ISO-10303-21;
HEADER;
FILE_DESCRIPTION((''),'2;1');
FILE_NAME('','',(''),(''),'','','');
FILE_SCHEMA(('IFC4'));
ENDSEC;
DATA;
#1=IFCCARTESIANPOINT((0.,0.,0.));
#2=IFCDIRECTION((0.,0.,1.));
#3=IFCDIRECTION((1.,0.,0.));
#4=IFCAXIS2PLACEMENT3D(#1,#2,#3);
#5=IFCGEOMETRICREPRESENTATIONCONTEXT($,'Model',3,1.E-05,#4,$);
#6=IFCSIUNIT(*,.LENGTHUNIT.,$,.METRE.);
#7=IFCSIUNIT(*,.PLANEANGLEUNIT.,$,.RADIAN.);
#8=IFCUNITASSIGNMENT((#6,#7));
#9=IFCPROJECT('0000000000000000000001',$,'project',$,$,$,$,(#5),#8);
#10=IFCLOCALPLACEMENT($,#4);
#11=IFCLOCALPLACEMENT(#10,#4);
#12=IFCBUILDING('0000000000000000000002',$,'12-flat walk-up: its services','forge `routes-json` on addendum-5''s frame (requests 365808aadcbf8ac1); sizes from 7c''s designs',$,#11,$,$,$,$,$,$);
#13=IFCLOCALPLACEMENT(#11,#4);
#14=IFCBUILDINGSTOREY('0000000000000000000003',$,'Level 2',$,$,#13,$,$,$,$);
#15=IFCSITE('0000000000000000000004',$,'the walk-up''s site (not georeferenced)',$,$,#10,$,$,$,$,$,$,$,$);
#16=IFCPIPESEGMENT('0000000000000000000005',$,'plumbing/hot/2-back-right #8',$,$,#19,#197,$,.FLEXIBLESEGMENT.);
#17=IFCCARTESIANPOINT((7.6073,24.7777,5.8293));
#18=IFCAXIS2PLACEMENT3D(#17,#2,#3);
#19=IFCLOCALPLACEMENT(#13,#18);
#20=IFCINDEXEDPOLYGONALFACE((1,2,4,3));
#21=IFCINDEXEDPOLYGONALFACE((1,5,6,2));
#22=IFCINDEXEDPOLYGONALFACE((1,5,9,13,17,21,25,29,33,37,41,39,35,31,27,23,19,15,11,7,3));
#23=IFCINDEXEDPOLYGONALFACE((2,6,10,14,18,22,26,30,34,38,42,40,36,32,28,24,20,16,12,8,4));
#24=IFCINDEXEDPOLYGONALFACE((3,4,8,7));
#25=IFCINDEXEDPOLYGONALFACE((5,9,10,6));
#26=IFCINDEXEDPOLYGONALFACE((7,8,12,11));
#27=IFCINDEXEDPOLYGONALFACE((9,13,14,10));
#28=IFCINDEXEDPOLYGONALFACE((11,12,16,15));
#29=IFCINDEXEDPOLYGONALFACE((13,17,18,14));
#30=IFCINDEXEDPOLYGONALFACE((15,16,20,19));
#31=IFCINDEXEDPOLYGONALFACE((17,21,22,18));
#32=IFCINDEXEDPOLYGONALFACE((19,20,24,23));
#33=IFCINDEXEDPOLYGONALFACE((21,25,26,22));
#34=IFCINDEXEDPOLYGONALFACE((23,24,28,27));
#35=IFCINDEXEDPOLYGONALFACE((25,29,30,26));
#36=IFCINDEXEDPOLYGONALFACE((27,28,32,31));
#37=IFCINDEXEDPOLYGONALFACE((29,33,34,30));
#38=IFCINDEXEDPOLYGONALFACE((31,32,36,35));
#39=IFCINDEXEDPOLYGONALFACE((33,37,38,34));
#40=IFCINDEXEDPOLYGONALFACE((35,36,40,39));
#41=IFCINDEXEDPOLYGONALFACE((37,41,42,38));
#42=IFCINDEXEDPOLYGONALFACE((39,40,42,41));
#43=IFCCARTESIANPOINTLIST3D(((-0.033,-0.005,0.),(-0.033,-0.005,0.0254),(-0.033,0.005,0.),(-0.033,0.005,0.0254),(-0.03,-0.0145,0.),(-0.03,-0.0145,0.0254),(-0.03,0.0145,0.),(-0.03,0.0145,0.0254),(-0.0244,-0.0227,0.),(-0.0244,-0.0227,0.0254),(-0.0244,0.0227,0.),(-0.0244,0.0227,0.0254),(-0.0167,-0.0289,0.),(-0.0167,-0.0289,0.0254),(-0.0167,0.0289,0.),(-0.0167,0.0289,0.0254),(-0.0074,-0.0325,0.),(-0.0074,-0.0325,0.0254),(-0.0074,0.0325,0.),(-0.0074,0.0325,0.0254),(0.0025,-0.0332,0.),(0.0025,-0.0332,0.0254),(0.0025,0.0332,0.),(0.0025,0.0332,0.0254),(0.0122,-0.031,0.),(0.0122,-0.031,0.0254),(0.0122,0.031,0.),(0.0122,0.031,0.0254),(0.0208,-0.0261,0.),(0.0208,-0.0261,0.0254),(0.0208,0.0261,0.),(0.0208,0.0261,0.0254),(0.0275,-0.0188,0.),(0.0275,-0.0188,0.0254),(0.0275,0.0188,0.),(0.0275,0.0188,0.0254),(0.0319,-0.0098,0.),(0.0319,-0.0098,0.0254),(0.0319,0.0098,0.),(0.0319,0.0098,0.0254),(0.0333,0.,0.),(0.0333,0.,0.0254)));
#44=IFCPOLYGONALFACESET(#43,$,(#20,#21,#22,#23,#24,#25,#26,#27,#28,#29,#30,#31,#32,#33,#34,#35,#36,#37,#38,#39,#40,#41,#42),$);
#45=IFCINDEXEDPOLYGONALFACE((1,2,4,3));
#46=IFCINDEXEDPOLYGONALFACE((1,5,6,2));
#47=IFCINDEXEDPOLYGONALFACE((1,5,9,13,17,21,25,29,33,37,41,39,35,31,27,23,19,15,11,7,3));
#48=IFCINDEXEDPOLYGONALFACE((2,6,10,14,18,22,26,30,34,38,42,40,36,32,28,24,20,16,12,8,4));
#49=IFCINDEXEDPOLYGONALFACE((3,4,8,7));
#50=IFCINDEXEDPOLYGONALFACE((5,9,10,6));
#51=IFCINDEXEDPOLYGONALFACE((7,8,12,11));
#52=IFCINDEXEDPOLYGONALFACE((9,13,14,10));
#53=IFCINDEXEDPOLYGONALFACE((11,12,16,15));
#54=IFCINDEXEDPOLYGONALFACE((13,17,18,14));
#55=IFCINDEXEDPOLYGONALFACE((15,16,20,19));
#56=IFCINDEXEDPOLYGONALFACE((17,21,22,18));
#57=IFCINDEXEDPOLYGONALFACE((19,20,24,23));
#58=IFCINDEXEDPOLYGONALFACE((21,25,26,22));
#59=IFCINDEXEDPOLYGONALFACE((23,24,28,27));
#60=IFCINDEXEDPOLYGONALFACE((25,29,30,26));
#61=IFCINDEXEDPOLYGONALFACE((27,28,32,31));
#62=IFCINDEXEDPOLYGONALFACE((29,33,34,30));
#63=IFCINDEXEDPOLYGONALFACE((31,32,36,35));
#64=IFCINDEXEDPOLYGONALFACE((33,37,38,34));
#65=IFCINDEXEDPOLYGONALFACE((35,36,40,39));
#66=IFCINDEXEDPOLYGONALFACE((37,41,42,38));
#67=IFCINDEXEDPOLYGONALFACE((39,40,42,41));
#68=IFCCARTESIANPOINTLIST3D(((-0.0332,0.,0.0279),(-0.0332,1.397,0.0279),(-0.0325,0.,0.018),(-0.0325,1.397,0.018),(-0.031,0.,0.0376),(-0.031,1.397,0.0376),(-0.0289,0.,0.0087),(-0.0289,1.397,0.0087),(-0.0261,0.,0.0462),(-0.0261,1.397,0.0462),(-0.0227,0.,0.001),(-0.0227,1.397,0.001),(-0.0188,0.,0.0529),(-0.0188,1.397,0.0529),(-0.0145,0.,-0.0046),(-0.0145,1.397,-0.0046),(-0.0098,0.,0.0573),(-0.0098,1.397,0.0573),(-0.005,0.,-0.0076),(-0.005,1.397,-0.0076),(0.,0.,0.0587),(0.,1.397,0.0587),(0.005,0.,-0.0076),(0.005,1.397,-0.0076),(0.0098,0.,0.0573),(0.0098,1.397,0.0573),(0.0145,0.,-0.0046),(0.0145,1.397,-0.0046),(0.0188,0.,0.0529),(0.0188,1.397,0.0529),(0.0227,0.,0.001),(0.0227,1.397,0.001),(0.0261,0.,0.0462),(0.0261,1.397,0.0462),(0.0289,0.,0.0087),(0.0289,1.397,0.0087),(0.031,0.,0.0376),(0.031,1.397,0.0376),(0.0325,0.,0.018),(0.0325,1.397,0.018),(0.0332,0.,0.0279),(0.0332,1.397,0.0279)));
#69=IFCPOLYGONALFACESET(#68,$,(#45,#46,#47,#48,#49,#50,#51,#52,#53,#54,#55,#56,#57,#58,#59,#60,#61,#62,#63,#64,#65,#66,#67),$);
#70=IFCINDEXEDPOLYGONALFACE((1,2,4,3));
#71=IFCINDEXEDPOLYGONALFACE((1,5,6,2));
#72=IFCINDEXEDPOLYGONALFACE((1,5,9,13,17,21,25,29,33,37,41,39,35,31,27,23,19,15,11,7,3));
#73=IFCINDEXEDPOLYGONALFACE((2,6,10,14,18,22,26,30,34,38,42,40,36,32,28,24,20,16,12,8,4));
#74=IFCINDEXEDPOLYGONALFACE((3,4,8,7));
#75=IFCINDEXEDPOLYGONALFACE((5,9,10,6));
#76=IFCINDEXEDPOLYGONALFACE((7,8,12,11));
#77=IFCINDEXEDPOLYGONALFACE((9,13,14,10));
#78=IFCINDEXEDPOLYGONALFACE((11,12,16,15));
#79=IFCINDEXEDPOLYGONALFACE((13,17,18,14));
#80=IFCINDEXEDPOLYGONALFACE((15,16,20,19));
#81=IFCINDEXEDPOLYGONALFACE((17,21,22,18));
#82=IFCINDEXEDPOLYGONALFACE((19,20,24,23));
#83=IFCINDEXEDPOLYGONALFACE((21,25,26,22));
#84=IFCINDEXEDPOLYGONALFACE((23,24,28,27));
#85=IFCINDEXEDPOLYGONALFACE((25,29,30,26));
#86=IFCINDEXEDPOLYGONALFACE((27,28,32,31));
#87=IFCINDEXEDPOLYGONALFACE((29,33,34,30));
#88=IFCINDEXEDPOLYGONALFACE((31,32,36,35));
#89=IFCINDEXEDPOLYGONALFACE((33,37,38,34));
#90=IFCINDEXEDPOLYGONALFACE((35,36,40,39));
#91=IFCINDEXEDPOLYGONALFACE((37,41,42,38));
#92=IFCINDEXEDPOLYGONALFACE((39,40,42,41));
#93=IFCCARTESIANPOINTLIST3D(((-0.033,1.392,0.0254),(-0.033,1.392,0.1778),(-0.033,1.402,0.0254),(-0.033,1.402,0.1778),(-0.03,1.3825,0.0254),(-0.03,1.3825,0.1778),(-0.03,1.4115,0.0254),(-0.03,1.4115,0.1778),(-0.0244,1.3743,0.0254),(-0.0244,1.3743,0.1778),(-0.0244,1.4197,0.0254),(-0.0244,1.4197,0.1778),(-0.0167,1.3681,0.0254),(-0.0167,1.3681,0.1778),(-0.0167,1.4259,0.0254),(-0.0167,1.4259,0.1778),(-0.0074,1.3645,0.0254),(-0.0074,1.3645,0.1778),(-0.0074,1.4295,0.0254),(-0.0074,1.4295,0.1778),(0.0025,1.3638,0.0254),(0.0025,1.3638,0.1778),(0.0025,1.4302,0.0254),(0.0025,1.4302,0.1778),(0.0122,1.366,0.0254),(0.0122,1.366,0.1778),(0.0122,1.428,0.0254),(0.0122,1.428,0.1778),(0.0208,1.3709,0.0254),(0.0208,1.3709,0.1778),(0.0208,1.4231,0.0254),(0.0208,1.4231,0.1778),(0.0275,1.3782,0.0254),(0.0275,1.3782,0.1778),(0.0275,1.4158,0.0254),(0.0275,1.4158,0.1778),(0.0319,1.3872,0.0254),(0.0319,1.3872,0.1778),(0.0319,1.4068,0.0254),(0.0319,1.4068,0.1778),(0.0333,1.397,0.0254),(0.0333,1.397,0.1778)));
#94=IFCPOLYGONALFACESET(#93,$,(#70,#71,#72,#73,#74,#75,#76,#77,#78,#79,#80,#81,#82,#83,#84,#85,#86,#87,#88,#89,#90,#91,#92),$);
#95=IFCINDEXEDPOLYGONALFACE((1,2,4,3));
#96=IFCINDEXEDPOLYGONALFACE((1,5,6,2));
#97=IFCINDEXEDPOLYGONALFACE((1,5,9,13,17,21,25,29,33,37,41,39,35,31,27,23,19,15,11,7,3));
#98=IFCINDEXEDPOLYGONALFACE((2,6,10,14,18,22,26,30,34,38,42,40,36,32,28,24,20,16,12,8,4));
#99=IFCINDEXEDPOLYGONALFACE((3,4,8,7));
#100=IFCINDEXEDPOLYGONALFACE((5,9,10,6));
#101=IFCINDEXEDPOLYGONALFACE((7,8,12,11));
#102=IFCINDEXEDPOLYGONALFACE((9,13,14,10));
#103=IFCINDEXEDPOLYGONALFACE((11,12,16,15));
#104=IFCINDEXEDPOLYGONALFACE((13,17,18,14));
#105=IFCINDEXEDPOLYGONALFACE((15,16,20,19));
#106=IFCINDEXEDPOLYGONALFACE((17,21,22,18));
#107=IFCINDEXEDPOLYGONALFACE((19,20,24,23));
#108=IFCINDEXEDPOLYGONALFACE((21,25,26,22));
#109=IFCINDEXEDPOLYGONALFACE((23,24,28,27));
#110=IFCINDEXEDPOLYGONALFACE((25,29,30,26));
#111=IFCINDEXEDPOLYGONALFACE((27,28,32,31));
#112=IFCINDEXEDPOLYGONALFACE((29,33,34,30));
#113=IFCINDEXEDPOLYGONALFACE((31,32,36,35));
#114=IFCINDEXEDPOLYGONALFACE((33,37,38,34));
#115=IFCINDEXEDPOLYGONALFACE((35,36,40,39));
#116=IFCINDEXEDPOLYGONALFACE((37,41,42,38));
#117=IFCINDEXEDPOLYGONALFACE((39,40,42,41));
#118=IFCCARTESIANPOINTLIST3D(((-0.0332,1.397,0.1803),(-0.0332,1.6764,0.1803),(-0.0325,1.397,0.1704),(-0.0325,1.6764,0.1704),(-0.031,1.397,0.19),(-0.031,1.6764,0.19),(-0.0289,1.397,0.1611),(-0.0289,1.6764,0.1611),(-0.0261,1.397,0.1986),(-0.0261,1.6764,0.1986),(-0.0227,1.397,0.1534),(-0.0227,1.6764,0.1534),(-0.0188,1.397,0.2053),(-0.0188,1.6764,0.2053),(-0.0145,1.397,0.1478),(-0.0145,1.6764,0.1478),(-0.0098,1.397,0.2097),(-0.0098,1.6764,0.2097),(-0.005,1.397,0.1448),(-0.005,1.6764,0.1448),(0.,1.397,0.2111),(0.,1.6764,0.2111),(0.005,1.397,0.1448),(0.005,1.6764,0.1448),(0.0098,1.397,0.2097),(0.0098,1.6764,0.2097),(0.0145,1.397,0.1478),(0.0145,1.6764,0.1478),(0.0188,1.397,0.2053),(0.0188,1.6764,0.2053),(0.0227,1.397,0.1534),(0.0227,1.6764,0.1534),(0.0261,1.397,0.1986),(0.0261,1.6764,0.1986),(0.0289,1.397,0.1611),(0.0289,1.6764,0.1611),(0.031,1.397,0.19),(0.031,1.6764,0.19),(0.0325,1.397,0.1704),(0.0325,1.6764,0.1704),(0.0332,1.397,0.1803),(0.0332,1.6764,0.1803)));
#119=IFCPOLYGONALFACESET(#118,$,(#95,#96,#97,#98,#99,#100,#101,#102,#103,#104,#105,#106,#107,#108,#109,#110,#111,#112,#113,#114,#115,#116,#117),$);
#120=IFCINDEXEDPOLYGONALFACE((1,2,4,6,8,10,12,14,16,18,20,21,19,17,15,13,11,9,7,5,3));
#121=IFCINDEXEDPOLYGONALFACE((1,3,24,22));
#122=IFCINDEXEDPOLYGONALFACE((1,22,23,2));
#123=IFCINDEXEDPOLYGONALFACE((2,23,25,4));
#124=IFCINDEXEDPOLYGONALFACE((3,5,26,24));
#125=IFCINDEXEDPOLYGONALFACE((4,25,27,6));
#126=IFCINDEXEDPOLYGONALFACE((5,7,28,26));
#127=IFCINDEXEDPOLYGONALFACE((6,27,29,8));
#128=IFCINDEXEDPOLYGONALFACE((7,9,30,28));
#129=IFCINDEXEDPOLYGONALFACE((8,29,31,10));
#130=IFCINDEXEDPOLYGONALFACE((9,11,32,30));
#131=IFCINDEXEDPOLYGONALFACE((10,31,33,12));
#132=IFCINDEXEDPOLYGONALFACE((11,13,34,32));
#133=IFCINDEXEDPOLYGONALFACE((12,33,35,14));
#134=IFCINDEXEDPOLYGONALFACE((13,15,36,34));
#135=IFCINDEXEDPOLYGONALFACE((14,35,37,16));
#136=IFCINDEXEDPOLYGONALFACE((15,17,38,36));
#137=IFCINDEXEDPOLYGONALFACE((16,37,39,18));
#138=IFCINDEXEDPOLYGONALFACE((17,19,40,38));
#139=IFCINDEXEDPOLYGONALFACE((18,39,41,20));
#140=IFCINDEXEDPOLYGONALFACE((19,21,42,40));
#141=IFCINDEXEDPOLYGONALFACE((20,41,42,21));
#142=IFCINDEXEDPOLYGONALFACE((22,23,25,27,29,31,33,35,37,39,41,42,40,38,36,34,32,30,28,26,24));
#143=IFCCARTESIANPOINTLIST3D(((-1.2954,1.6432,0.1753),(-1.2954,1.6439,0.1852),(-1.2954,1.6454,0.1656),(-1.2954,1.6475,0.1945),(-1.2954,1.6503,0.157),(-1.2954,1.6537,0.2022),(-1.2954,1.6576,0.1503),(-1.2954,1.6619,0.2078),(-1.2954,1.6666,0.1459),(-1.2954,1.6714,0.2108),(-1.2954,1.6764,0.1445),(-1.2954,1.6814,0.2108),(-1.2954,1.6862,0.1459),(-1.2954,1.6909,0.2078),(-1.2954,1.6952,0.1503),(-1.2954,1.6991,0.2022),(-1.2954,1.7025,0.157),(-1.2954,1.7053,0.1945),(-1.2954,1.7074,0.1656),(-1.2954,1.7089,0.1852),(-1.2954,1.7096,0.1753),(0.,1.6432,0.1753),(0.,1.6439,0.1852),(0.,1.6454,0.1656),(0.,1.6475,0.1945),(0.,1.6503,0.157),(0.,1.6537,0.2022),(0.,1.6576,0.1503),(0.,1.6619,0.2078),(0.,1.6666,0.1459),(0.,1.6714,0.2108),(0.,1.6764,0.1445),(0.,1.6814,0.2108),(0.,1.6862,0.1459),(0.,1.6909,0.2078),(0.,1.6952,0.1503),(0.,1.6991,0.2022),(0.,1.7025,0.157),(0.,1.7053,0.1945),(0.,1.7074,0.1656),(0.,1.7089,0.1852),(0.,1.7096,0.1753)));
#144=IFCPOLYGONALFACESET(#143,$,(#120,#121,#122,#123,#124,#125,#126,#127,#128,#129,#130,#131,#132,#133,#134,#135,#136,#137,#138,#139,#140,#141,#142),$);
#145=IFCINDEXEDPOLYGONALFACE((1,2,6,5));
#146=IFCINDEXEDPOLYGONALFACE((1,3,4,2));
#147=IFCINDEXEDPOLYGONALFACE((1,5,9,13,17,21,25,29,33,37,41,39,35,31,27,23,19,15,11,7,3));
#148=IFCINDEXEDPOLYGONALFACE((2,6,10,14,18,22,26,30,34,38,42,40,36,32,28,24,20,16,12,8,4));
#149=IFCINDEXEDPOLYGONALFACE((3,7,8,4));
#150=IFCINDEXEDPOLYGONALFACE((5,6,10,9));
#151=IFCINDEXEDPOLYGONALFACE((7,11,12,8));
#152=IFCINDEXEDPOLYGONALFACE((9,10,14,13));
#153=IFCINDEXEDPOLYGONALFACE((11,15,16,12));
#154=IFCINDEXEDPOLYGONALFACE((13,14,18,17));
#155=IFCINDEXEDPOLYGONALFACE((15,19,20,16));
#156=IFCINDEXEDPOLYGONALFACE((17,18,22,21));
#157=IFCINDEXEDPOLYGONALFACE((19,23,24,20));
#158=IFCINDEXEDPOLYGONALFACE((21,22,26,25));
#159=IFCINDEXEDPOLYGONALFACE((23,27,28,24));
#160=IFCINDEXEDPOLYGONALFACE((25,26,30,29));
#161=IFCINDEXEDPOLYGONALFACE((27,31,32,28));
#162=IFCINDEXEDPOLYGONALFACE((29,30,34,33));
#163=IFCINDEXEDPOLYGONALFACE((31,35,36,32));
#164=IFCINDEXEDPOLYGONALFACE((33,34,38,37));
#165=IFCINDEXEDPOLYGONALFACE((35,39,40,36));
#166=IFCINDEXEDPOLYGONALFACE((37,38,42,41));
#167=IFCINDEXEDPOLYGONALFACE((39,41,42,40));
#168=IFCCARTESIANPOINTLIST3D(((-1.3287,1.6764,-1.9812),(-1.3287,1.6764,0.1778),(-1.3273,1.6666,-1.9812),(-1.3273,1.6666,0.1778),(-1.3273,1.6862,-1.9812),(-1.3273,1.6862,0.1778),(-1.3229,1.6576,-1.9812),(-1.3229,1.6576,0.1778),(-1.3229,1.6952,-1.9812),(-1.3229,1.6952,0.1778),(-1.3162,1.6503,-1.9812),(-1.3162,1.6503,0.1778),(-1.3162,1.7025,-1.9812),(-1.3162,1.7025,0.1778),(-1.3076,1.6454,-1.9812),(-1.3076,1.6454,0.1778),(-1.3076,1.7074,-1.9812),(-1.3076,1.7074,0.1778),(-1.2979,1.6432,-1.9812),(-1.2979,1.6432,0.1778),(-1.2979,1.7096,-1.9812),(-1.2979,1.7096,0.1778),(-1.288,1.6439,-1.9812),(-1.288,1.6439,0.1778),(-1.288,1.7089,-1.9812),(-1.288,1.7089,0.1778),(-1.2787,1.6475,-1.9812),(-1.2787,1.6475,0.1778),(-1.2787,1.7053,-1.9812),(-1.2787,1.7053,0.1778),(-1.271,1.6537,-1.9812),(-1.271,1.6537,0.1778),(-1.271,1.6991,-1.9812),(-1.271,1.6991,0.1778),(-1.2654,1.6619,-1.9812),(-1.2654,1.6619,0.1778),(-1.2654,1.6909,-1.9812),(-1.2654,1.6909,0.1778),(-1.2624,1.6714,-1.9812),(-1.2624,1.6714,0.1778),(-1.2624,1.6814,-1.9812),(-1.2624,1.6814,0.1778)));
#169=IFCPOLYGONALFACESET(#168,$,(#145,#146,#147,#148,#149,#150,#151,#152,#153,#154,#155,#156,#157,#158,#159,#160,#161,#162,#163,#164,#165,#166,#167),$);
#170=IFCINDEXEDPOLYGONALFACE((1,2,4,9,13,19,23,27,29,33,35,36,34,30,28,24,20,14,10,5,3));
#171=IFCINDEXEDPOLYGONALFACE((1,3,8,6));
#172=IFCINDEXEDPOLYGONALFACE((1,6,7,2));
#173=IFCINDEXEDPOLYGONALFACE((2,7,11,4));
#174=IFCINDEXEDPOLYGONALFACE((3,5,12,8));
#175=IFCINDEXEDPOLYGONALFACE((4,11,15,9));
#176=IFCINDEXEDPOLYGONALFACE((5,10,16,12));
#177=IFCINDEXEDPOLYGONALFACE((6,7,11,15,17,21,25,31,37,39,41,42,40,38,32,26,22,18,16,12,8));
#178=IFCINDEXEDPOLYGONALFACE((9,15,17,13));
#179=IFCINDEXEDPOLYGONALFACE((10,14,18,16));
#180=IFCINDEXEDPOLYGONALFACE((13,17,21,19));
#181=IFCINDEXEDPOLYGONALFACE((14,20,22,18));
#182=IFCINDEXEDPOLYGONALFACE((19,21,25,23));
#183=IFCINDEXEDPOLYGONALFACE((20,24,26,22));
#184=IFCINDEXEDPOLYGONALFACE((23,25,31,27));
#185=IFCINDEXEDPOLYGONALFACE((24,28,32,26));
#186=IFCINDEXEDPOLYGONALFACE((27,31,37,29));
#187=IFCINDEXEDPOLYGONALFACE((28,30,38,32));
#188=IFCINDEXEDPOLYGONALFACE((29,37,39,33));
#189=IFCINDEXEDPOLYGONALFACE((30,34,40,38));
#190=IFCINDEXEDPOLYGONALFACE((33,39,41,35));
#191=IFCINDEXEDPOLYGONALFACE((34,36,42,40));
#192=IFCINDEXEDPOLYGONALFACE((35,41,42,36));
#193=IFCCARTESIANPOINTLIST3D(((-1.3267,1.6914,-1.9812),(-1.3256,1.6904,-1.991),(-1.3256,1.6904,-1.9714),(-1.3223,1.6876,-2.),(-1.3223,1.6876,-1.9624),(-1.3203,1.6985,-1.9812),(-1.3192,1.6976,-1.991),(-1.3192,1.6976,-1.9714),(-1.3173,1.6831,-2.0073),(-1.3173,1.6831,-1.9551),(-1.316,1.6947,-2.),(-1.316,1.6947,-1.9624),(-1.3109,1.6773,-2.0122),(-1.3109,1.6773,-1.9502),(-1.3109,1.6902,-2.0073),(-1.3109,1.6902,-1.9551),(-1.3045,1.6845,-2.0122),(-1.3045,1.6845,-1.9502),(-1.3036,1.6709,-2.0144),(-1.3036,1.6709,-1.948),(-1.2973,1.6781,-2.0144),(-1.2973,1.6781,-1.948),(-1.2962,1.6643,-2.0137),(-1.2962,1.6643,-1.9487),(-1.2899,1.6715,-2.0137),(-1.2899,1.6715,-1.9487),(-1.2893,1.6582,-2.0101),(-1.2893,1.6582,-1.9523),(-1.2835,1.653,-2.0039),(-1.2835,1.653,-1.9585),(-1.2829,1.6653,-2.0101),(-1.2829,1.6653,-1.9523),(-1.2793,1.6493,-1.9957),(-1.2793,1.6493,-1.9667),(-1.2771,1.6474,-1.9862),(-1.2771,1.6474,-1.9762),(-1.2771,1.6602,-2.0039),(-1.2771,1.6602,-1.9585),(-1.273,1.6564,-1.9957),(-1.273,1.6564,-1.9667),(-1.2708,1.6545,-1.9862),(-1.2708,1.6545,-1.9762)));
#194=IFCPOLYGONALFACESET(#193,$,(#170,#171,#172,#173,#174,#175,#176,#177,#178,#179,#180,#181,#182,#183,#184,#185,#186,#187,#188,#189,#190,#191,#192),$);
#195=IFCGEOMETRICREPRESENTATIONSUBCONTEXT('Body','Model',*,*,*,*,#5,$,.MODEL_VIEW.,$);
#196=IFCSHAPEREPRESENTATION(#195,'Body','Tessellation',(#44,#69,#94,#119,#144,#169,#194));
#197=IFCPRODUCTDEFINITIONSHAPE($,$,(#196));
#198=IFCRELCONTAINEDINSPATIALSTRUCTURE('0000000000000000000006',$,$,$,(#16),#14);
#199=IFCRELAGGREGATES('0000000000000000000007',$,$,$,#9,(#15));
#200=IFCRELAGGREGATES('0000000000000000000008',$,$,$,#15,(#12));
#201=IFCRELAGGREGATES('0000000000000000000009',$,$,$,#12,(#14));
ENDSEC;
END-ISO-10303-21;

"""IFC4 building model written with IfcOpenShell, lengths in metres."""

from ifc_helpers import new_model, entity, si_unit, frame, origin_with_axes, place, context, subcontext, project, spatial, element, save


model = new_model("IFC4")

# Units and contexts
model_context = context("Model", 3, precision=1e-05, world=origin_with_axes())
body_context = subcontext(model_context, "Body", "Model", "MODEL_VIEW")
ifc_project = project(units=[si_unit("LENGTHUNIT", "METRE"), si_unit("PLANEANGLEUNIT", "RADIAN")], contexts=[model_context])

# Site, building, storey
site_placement = place(None, origin_with_axes())
site = spatial("IfcSite", under=ifc_project, at=site_placement, Name="the walk-up's site (not georeferenced)")
building_placement = place(site_placement, origin_with_axes())
building = spatial("IfcBuilding", under=site, at=building_placement, Name="12-flat walk-up: its services", Description="forge `routes-json` on addendum-5's frame (requests 365808aadcbf8ac1); sizes from 7c's designs")
storey_placement = place(building_placement, origin_with_axes())
storey = spatial("IfcBuildingStorey", under=building, at=storey_placement, Name="Level 2")

# Pipe segment
pipe_segment_1_placement = place(storey_placement, frame((7.6073, 24.7777, 5.8293), z_axis=(0.0, 0.0, 1.0), x_axis=(1.0, 0.0, 0.0)))
element("IfcPipeSegment", 1, at=pipe_segment_1_placement, inside=storey, Name="plumbing/hot/2-back-right #8", PredefinedType="FLEXIBLESEGMENT", context=body_context, shape_type="AdvancedSweptSolid", body=[
    entity("IfcSweptDiskSolid", entity("IfcPolyline", [entity("IfcCartesianPoint", [0.0, 0.0, 0.0]), entity("IfcCartesianPoint", [0.0, 0.0, 0.0254])]), 0.0333),
    entity("IfcSweptDiskSolid", entity("IfcPolyline", [entity("IfcCartesianPoint", [0.0, 0.0, 0.0254]), entity("IfcCartesianPoint", [0.0, 1.397, 0.0254])]), 0.0333),
    entity("IfcSweptDiskSolid", entity("IfcPolyline", [entity("IfcCartesianPoint", [0.0, 1.397, 0.0254]), entity("IfcCartesianPoint", [0.0, 1.397, 0.1778])]), 0.0333),
    entity("IfcSweptDiskSolid", entity("IfcPolyline", [entity("IfcCartesianPoint", [0.0, 1.397, 0.1778]), entity("IfcCartesianPoint", [0.0, 1.6764, 0.1778])]), 0.0333),
    entity("IfcSweptDiskSolid", entity("IfcPolyline", [entity("IfcCartesianPoint", [0.0, 1.6764, 0.1778]), entity("IfcCartesianPoint", [-1.2954, 1.6764, 0.1778])]), 0.0333),
    entity("IfcSweptDiskSolid", entity("IfcPolyline", [entity("IfcCartesianPoint", [-1.2954, 1.6764, 0.1778]), entity("IfcCartesianPoint", [-1.2954, 1.6764, -1.9812])]), 0.0333),
    entity("IfcSweptDiskSolid", entity("IfcPolyline", [entity("IfcCartesianPoint", [-1.2954, 1.6764, -1.9812]), entity("IfcCartesianPoint", [-1.3017, 1.6693, -1.9812])]), 0.0333),
])

save(model, "model.ifc")
